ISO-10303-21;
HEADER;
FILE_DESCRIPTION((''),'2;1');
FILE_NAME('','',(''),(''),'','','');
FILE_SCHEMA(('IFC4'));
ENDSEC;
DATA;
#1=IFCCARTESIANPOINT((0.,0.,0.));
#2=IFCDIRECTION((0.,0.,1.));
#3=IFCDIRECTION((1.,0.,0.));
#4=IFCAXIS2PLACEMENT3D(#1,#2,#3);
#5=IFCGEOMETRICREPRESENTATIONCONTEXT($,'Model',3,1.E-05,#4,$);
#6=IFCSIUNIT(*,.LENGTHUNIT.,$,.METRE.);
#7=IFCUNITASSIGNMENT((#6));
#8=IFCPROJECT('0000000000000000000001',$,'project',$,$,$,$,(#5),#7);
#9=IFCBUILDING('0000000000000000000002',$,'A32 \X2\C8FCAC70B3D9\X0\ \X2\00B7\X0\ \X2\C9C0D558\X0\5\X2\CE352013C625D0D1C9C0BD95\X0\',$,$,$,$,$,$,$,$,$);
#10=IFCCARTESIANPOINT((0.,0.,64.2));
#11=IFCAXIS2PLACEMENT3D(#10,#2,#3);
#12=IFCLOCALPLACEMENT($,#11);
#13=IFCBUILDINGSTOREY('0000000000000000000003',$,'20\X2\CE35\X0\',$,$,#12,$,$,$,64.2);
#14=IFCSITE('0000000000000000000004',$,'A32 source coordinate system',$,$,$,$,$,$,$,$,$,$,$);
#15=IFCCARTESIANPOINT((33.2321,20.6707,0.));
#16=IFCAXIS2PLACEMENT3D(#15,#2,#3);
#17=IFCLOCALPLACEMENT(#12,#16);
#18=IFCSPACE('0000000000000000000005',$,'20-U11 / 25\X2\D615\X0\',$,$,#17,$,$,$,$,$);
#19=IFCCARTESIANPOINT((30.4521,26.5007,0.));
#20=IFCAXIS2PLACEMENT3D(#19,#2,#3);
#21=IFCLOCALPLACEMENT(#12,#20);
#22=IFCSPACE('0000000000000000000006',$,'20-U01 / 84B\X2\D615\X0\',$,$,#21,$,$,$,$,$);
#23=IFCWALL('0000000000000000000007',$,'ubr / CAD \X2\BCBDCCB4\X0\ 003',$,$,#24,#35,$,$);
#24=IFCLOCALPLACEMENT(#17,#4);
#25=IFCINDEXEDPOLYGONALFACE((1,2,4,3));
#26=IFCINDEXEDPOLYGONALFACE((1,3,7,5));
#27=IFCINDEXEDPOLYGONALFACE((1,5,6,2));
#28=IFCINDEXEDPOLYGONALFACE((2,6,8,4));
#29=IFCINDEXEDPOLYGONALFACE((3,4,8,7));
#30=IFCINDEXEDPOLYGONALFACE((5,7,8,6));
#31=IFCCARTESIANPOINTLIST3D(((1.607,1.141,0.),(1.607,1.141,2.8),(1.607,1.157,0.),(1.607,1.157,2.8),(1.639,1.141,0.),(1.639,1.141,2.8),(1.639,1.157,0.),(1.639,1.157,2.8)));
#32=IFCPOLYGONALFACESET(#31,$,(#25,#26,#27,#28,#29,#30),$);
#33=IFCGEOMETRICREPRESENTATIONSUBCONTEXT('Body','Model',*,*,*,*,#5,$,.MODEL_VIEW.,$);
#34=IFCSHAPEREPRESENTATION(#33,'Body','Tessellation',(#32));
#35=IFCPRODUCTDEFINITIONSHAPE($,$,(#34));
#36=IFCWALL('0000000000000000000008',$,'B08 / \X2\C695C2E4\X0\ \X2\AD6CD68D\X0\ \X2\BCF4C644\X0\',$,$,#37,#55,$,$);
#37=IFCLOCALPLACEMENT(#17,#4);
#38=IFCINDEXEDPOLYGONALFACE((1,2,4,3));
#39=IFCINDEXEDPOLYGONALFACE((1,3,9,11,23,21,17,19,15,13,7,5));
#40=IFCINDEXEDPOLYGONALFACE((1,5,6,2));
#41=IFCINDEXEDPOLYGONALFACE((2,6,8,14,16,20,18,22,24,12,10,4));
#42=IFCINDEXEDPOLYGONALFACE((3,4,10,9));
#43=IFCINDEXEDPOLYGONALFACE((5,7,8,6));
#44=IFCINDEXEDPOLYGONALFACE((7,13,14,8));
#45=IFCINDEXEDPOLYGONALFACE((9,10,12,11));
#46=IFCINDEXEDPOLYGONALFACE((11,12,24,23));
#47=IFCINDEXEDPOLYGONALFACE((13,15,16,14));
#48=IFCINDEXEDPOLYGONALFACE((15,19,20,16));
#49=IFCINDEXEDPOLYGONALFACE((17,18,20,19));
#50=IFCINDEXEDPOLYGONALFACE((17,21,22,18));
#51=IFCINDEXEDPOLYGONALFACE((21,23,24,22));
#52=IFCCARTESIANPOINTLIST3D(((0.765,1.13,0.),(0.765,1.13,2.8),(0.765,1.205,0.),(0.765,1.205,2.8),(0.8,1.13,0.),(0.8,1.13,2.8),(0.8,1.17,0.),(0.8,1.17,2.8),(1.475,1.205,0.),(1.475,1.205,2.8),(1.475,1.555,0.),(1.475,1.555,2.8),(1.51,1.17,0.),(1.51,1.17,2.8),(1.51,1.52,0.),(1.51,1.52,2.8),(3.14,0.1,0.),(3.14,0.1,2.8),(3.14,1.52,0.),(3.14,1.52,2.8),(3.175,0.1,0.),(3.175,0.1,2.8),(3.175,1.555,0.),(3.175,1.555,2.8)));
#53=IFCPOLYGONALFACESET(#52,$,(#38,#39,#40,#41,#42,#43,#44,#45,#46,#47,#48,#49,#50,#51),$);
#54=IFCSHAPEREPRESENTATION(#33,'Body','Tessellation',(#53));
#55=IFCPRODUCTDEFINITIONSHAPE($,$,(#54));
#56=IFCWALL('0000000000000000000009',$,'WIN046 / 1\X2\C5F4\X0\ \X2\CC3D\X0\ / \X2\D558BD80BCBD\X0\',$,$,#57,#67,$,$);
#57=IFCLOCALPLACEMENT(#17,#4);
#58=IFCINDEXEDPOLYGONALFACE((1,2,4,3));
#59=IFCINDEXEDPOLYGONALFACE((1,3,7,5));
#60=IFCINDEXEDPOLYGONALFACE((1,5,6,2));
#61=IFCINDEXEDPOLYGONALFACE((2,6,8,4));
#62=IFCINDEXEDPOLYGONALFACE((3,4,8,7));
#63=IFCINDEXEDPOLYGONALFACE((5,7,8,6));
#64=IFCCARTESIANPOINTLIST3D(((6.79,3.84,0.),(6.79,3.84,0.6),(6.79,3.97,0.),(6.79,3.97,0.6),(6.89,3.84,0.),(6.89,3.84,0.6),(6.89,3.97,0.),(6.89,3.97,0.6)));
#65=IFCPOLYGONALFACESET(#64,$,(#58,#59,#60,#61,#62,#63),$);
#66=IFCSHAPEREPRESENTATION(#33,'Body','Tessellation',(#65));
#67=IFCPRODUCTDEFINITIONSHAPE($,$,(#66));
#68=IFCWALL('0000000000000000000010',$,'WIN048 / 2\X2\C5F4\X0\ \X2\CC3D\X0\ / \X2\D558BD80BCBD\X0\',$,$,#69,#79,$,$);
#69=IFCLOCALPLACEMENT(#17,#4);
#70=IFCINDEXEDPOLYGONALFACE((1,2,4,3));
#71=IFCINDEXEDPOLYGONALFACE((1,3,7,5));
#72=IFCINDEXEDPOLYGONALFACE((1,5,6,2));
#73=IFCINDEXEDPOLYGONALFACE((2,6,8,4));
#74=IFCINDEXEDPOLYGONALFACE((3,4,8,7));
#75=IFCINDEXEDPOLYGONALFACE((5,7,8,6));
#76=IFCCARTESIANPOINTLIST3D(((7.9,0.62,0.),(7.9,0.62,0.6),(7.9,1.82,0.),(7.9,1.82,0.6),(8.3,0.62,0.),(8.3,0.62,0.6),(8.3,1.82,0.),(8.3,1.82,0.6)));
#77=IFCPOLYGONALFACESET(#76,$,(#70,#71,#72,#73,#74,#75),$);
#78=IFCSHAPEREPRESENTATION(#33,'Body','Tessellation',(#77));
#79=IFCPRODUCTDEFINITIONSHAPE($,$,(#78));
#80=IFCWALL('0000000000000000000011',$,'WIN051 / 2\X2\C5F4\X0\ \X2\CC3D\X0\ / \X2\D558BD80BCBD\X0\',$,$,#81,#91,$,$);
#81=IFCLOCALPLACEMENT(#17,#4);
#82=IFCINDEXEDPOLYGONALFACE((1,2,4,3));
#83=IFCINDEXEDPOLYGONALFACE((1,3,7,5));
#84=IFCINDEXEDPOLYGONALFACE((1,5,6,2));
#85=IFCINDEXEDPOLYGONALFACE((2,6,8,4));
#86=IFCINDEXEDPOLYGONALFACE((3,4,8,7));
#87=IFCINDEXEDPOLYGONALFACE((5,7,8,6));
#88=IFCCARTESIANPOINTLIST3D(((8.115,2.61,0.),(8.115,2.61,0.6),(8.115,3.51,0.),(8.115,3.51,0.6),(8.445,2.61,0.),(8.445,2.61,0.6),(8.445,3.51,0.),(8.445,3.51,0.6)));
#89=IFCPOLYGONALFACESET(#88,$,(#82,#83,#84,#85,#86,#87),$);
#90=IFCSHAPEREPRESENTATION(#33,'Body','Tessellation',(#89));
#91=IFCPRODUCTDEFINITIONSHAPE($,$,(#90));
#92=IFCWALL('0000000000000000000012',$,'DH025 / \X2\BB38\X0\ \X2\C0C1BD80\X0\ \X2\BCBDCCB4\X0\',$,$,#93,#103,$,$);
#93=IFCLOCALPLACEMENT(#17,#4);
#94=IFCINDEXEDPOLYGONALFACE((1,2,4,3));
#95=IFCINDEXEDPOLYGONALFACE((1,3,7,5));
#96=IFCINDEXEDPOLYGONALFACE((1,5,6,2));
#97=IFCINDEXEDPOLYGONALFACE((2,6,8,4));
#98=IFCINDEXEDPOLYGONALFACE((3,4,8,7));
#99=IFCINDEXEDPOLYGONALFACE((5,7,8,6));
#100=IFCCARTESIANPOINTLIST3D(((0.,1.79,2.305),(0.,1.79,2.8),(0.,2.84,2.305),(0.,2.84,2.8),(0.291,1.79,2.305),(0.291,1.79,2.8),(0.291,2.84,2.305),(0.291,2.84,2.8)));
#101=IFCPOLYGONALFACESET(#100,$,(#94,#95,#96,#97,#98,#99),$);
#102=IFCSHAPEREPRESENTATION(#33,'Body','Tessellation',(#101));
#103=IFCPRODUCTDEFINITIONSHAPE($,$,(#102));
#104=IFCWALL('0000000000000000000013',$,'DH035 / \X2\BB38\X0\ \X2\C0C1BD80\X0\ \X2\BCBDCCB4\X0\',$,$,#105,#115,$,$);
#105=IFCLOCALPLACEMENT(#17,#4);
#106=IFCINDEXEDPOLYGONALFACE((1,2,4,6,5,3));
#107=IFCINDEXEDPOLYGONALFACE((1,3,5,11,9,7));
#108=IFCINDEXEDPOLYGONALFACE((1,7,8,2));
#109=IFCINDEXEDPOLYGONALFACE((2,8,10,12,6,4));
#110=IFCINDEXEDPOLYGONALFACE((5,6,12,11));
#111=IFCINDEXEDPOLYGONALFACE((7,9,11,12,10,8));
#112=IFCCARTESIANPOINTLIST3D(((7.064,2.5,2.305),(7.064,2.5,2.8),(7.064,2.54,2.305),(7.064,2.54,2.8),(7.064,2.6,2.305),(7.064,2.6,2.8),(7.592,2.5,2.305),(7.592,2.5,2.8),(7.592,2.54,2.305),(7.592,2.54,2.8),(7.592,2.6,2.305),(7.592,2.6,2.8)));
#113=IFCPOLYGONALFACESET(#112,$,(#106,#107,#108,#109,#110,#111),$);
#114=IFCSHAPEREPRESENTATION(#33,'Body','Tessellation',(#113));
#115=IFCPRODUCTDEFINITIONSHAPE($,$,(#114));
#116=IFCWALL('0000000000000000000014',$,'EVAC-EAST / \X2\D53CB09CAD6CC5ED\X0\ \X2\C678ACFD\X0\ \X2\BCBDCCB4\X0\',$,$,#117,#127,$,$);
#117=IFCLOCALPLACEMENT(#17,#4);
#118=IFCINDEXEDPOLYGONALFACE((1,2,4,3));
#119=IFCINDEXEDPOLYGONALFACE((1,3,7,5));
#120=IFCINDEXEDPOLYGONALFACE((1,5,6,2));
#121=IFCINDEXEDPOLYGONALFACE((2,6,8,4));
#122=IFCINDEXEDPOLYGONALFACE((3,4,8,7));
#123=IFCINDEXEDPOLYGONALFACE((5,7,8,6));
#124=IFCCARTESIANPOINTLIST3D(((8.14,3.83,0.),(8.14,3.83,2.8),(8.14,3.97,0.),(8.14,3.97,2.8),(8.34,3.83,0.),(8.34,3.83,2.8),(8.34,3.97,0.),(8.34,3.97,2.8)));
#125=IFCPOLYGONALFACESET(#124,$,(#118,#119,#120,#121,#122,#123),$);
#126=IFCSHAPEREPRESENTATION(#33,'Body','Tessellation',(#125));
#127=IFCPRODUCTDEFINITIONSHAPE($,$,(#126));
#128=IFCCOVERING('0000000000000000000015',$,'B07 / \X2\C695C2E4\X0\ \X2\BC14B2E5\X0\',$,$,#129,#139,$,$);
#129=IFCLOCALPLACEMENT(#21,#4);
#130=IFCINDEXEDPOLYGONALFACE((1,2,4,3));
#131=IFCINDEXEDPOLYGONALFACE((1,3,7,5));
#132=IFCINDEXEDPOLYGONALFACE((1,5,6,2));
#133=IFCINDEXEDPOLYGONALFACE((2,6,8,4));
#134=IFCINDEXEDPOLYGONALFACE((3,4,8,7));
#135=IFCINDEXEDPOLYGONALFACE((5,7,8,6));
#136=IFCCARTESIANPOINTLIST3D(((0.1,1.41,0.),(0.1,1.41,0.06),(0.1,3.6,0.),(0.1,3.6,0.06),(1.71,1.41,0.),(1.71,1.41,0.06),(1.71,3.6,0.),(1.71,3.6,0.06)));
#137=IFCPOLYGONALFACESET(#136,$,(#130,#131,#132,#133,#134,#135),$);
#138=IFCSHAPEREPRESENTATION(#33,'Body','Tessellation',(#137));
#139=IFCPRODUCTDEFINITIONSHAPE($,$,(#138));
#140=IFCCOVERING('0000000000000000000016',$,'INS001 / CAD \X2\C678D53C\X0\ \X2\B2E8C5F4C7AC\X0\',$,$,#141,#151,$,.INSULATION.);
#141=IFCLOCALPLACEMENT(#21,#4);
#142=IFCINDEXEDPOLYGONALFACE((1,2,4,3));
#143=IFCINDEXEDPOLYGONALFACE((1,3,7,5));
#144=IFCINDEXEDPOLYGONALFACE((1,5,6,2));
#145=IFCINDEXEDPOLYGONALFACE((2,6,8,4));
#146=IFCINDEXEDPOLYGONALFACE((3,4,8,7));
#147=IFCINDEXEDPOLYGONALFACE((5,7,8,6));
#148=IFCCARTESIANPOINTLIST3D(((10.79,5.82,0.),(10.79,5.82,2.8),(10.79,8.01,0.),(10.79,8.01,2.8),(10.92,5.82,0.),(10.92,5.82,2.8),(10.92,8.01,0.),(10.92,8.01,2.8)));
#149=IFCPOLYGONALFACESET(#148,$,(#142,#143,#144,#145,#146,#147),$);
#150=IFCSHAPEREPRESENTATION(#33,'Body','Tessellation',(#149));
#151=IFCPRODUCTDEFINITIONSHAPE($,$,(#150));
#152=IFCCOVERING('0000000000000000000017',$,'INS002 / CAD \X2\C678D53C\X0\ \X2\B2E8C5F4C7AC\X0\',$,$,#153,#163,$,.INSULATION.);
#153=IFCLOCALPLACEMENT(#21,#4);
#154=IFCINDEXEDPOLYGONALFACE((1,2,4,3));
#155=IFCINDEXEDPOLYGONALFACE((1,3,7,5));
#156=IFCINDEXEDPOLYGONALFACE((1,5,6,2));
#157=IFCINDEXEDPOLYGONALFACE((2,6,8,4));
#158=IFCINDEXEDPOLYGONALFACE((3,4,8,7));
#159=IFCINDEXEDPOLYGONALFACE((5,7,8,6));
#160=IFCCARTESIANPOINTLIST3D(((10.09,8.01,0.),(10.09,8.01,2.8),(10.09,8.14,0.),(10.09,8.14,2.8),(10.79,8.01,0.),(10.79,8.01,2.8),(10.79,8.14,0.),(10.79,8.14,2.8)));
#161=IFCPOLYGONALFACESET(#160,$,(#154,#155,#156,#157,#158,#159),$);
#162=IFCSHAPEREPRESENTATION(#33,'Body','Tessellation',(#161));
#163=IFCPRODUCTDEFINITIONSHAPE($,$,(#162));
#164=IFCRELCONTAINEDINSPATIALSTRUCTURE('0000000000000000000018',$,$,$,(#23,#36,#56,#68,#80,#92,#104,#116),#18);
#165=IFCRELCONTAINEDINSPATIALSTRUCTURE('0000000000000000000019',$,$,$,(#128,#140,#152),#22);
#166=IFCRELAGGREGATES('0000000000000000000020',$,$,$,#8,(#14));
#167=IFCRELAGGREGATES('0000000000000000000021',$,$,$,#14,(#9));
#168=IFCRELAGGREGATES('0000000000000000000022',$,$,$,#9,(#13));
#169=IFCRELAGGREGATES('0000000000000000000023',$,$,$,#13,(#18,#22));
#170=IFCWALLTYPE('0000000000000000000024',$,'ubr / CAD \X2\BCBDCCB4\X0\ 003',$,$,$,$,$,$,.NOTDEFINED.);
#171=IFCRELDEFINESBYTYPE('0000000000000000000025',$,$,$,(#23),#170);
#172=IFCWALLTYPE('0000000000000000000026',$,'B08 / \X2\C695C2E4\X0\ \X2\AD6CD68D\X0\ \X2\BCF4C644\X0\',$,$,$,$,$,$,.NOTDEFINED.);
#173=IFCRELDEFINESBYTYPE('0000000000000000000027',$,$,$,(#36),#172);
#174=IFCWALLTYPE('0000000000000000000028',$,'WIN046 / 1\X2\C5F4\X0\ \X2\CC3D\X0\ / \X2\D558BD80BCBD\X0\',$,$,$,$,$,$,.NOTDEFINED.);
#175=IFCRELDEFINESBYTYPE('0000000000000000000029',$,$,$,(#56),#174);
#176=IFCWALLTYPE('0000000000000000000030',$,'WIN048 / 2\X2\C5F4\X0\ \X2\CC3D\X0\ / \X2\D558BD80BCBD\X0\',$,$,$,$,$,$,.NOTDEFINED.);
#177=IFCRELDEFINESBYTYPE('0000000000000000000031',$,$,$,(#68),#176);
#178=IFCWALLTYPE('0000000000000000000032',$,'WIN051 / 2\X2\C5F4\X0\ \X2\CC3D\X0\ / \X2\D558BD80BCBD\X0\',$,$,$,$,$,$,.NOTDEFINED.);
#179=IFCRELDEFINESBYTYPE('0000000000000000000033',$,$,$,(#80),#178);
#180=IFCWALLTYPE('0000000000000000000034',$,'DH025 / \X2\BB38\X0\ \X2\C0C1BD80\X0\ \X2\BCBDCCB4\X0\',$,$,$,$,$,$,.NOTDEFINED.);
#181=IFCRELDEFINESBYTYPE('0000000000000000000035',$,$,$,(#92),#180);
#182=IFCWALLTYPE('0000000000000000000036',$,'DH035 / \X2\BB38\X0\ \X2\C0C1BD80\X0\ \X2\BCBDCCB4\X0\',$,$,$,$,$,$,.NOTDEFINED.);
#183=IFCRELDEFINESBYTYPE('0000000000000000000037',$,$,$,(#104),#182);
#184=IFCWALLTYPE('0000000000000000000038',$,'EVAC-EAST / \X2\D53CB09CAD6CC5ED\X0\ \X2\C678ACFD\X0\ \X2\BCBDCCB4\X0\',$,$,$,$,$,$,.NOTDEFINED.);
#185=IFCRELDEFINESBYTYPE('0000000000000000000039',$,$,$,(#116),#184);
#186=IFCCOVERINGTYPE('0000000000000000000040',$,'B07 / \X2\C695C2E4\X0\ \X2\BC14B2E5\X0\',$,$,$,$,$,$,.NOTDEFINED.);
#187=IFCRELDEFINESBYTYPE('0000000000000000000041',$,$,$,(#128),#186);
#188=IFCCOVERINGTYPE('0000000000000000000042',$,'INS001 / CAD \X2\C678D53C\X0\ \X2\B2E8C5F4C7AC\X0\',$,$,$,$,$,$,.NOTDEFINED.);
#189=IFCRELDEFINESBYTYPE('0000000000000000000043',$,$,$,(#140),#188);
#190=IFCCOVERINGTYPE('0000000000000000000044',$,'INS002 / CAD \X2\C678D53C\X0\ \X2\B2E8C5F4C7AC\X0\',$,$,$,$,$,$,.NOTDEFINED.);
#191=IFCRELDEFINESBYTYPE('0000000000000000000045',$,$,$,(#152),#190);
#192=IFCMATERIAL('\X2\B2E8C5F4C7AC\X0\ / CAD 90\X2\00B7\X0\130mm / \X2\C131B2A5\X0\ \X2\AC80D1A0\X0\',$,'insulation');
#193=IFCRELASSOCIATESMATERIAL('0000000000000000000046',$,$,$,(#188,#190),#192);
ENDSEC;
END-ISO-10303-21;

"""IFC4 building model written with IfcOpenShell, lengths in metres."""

from ifc_helpers import new_model, si_unit, frame, origin, origin_with_axes, place, context, subcontext, project, spatial, polyline, outline, extrude, source, transform, mapped, material, type_object, type_shapes, element, save


model = new_model("IFC4")

# Units and contexts
model_context = context("Model", 3, precision=1e-05, world=origin_with_axes())
body_context = subcontext(model_context, "Body", "Model", "MODEL_VIEW")
ifc_project = project(units=[si_unit("LENGTHUNIT", "METRE")], contexts=[model_context])

# Site, building, storey, space
site = spatial("IfcSite", under=ifc_project, Name="A32 source coordinate system")
building = spatial("IfcBuilding", under=site, Name="A32 주거동 · 지하5층–옥탑지붕")
storey_placement = place(None, frame((0.0, 0.0, 64.2), z_axis=(0.0, 0.0, 1.0), x_axis=(1.0, 0.0, 0.0)))
storey = spatial("IfcBuildingStorey", under=building, at=storey_placement, Name="20층", Elevation=64.2)
space_1_placement = place(storey_placement, frame((33.2321, 20.6707, 0.0), z_axis=(0.0, 0.0, 1.0), x_axis=(1.0, 0.0, 0.0)))
space_1 = spatial("IfcSpace", under=storey, at=space_1_placement, Name="20-U11 / 25형")

# Walls
wall_type_1 = type_object("IfcWallType", Name="ubr / CAD 벽체 003", PredefinedType="NOTDEFINED")
shared_shape_1 = source(origin(), body_context, "Body", "SweptSolid", [
    extrude(outline(polyline([(1.639, 1.157), (1.639, 1.141), (1.607, 1.141), (1.607, 1.157), (1.639, 1.157)])), origin(), (0.0, 0.0, 1.0), 2.8),
])
type_shapes(wall_type_1, [shared_shape_1])
wall_1_placement = place(space_1_placement, origin_with_axes())
element("IfcWall", 1, at=wall_1_placement, inside=space_1, type_object=wall_type_1, Name="ubr / CAD 벽체 003", context=body_context, shape_type="MappedRepresentation", body=[
    mapped(shared_shape_1, transform((0.0, 0.0, 0.0), scale=1.0)),
])
wall_type_2 = type_object("IfcWallType", Name="B08 / 욕실 구획 보완", PredefinedType="NOTDEFINED")
shared_shape_2 = source(origin(), body_context, "Body", "SweptSolid", [
    extrude(outline(polyline([(0.765, 1.205), (1.475, 1.205), (1.475, 1.555), (3.175, 1.555), (3.175, 0.1), (3.14, 0.1), (3.14, 1.52), (1.51, 1.52), (1.51, 1.17), (0.8, 1.17), (0.8, 1.13), (0.765, 1.13), (0.765, 1.205)])), origin(), (0.0, 0.0, 1.0), 2.8),
])
type_shapes(wall_type_2, [shared_shape_2])
wall_2_placement = place(space_1_placement, origin_with_axes())
element("IfcWall", 2, at=wall_2_placement, inside=space_1, type_object=wall_type_2, Name="B08 / 욕실 구획 보완", context=body_context, shape_type="MappedRepresentation", body=[
    mapped(shared_shape_2, transform((0.0, 0.0, 0.0), scale=1.0)),
])
wall_type_3 = type_object("IfcWallType", Name="WIN046 / 1열 창 / 하부벽", PredefinedType="NOTDEFINED")
shared_shape_3 = source(origin(), body_context, "Body", "SweptSolid", [
    extrude(outline(polyline([(6.89, 3.84), (6.79, 3.84), (6.79, 3.97), (6.89, 3.97), (6.89, 3.84)])), origin(), (0.0, 0.0, 1.0), 0.6),
])
type_shapes(wall_type_3, [shared_shape_3])
wall_3_placement = place(space_1_placement, origin_with_axes())
element("IfcWall", 3, at=wall_3_placement, inside=space_1, type_object=wall_type_3, Name="WIN046 / 1열 창 / 하부벽", context=body_context, shape_type="MappedRepresentation", body=[
    mapped(shared_shape_3, transform((0.0, 0.0, 0.0), scale=1.0)),
])
wall_type_4 = type_object("IfcWallType", Name="WIN048 / 2열 창 / 하부벽", PredefinedType="NOTDEFINED")
shared_shape_4 = source(origin(), body_context, "Body", "SweptSolid", [
    extrude(outline(polyline([(8.3, 0.62), (7.9, 0.62), (7.9, 1.82), (8.3, 1.82), (8.3, 0.62)])), origin(), (0.0, 0.0, 1.0), 0.6),
])
type_shapes(wall_type_4, [shared_shape_4])
wall_4_placement = place(space_1_placement, origin_with_axes())
element("IfcWall", 4, at=wall_4_placement, inside=space_1, type_object=wall_type_4, Name="WIN048 / 2열 창 / 하부벽", context=body_context, shape_type="MappedRepresentation", body=[
    mapped(shared_shape_4, transform((0.0, 0.0, 0.0), scale=1.0)),
])
wall_type_5 = type_object("IfcWallType", Name="WIN051 / 2열 창 / 하부벽", PredefinedType="NOTDEFINED")
shared_shape_5 = source(origin(), body_context, "Body", "SweptSolid", [
    extrude(outline(polyline([(8.445, 2.61), (8.115, 2.61), (8.115, 3.51), (8.445, 3.51), (8.445, 2.61)])), origin(), (0.0, 0.0, 1.0), 0.6),
])
type_shapes(wall_type_5, [shared_shape_5])
wall_5_placement = place(space_1_placement, origin_with_axes())
element("IfcWall", 5, at=wall_5_placement, inside=space_1, type_object=wall_type_5, Name="WIN051 / 2열 창 / 하부벽", context=body_context, shape_type="MappedRepresentation", body=[
    mapped(shared_shape_5, transform((0.0, 0.0, 0.0), scale=1.0)),
])
wall_type_6 = type_object("IfcWallType", Name="DH025 / 문 상부 벽체", PredefinedType="NOTDEFINED")
shared_shape_6 = source(origin(), body_context, "Body", "SweptSolid", [
    extrude(outline(polyline([(0.0, 1.79), (0.0, 2.84), (0.291, 2.84), (0.291, 1.79), (0.0, 1.79)])), frame((0.0, 0.0, 2.305)), (0.0, 0.0, 1.0), 0.495),
])
type_shapes(wall_type_6, [shared_shape_6])
wall_6_placement = place(space_1_placement, origin_with_axes())
element("IfcWall", 6, at=wall_6_placement, inside=space_1, type_object=wall_type_6, Name="DH025 / 문 상부 벽체", context=body_context, shape_type="MappedRepresentation", body=[
    mapped(shared_shape_6, transform((0.0, 0.0, 0.0), scale=1.0)),
])
wall_type_7 = type_object("IfcWallType", Name="DH035 / 문 상부 벽체", PredefinedType="NOTDEFINED")
shared_shape_7 = source(origin(), body_context, "Body", "SweptSolid", [
    extrude(outline(polyline([(7.592, 2.6), (7.592, 2.54), (7.592, 2.5), (7.064, 2.5), (7.064, 2.54), (7.064, 2.6), (7.592, 2.6)])), frame((0.0, 0.0, 2.305)), (0.0, 0.0, 1.0), 0.495),
])
type_shapes(wall_type_7, [shared_shape_7])
wall_7_placement = place(space_1_placement, origin_with_axes())
element("IfcWall", 7, at=wall_7_placement, inside=space_1, type_object=wall_type_7, Name="DH035 / 문 상부 벽체", context=body_context, shape_type="MappedRepresentation", body=[
    mapped(shared_shape_7, transform((0.0, 0.0, 0.0), scale=1.0)),
])
wall_type_8 = type_object("IfcWallType", Name="EVAC-EAST / 피난구역 외곽 벽체", PredefinedType="NOTDEFINED")
shared_shape_8 = source(origin(), body_context, "Body", "SweptSolid", [
    extrude(outline(polyline([(8.34, 3.83), (8.14, 3.83), (8.14, 3.97), (8.34, 3.97), (8.34, 3.83)])), origin(), (0.0, 0.0, 1.0), 2.8),
])
type_shapes(wall_type_8, [shared_shape_8])
wall_8_placement = place(space_1_placement, origin_with_axes())
element("IfcWall", 8, at=wall_8_placement, inside=space_1, type_object=wall_type_8, Name="EVAC-EAST / 피난구역 외곽 벽체", context=body_context, shape_type="MappedRepresentation", body=[
    mapped(shared_shape_8, transform((0.0, 0.0, 0.0), scale=1.0)),
])

# Shared definitions
space_2_placement = place(storey_placement, frame((30.4521, 26.5007, 0.0), z_axis=(0.0, 0.0, 1.0), x_axis=(1.0, 0.0, 0.0)))
space_2 = spatial("IfcSpace", under=storey, at=space_2_placement, Name="20-U01 / 84B형")

# Coverings
covering_type_1 = type_object("IfcCoveringType", Name="B07 / 욕실 바닥", PredefinedType="NOTDEFINED")
shared_shape_9 = source(origin(), body_context, "Body", "SweptSolid", [
    extrude(outline(polyline([(1.71, 1.41), (0.1, 1.41), (0.1, 3.6), (1.71, 3.6), (1.71, 1.41)])), origin(), (0.0, 0.0, 1.0), 0.06),
])
type_shapes(covering_type_1, [shared_shape_9])
covering_1_placement = place(space_2_placement, origin_with_axes())
element("IfcCovering", 9, at=covering_1_placement, inside=space_2, type_object=covering_type_1, Name="B07 / 욕실 바닥", context=body_context, shape_type="MappedRepresentation", body=[
    mapped(shared_shape_9, transform((0.0, 0.0, 0.0), scale=1.0)),
])
ifc_material = material(Name="단열재 / CAD 90·130mm / 성능 검토", Category="insulation")
covering_type_2 = type_object("IfcCoveringType", Name="INS001 / CAD 외피 단열재", PredefinedType="NOTDEFINED", material=ifc_material)
shared_shape_10 = source(origin(), body_context, "Body", "SweptSolid", [
    extrude(outline(polyline([(10.79, 5.82), (10.79, 8.01), (10.92, 8.01), (10.92, 5.82), (10.79, 5.82)])), origin(), (0.0, 0.0, 1.0), 2.8),
])
type_shapes(covering_type_2, [shared_shape_10])
covering_2_placement = place(space_2_placement, origin_with_axes())
element("IfcCovering", 10, at=covering_2_placement, inside=space_2, type_object=covering_type_2, Name="INS001 / CAD 외피 단열재", PredefinedType="INSULATION", context=body_context, shape_type="MappedRepresentation", body=[
    mapped(shared_shape_10, transform((0.0, 0.0, 0.0), scale=1.0)),
])
covering_type_3 = type_object("IfcCoveringType", Name="INS002 / CAD 외피 단열재", PredefinedType="NOTDEFINED", material=ifc_material)
shared_shape_11 = source(origin(), body_context, "Body", "SweptSolid", [
    extrude(outline(polyline([(10.79, 8.01), (10.09, 8.01), (10.09, 8.14), (10.79, 8.14), (10.79, 8.01)])), origin(), (0.0, 0.0, 1.0), 2.8),
])
type_shapes(covering_type_3, [shared_shape_11])
covering_3_placement = place(space_2_placement, origin_with_axes())
element("IfcCovering", 11, at=covering_3_placement, inside=space_2, type_object=covering_type_3, Name="INS002 / CAD 외피 단열재", PredefinedType="INSULATION", context=body_context, shape_type="MappedRepresentation", body=[
    mapped(shared_shape_11, transform((0.0, 0.0, 0.0), scale=1.0)),
])

save(model, "model.ifc")
